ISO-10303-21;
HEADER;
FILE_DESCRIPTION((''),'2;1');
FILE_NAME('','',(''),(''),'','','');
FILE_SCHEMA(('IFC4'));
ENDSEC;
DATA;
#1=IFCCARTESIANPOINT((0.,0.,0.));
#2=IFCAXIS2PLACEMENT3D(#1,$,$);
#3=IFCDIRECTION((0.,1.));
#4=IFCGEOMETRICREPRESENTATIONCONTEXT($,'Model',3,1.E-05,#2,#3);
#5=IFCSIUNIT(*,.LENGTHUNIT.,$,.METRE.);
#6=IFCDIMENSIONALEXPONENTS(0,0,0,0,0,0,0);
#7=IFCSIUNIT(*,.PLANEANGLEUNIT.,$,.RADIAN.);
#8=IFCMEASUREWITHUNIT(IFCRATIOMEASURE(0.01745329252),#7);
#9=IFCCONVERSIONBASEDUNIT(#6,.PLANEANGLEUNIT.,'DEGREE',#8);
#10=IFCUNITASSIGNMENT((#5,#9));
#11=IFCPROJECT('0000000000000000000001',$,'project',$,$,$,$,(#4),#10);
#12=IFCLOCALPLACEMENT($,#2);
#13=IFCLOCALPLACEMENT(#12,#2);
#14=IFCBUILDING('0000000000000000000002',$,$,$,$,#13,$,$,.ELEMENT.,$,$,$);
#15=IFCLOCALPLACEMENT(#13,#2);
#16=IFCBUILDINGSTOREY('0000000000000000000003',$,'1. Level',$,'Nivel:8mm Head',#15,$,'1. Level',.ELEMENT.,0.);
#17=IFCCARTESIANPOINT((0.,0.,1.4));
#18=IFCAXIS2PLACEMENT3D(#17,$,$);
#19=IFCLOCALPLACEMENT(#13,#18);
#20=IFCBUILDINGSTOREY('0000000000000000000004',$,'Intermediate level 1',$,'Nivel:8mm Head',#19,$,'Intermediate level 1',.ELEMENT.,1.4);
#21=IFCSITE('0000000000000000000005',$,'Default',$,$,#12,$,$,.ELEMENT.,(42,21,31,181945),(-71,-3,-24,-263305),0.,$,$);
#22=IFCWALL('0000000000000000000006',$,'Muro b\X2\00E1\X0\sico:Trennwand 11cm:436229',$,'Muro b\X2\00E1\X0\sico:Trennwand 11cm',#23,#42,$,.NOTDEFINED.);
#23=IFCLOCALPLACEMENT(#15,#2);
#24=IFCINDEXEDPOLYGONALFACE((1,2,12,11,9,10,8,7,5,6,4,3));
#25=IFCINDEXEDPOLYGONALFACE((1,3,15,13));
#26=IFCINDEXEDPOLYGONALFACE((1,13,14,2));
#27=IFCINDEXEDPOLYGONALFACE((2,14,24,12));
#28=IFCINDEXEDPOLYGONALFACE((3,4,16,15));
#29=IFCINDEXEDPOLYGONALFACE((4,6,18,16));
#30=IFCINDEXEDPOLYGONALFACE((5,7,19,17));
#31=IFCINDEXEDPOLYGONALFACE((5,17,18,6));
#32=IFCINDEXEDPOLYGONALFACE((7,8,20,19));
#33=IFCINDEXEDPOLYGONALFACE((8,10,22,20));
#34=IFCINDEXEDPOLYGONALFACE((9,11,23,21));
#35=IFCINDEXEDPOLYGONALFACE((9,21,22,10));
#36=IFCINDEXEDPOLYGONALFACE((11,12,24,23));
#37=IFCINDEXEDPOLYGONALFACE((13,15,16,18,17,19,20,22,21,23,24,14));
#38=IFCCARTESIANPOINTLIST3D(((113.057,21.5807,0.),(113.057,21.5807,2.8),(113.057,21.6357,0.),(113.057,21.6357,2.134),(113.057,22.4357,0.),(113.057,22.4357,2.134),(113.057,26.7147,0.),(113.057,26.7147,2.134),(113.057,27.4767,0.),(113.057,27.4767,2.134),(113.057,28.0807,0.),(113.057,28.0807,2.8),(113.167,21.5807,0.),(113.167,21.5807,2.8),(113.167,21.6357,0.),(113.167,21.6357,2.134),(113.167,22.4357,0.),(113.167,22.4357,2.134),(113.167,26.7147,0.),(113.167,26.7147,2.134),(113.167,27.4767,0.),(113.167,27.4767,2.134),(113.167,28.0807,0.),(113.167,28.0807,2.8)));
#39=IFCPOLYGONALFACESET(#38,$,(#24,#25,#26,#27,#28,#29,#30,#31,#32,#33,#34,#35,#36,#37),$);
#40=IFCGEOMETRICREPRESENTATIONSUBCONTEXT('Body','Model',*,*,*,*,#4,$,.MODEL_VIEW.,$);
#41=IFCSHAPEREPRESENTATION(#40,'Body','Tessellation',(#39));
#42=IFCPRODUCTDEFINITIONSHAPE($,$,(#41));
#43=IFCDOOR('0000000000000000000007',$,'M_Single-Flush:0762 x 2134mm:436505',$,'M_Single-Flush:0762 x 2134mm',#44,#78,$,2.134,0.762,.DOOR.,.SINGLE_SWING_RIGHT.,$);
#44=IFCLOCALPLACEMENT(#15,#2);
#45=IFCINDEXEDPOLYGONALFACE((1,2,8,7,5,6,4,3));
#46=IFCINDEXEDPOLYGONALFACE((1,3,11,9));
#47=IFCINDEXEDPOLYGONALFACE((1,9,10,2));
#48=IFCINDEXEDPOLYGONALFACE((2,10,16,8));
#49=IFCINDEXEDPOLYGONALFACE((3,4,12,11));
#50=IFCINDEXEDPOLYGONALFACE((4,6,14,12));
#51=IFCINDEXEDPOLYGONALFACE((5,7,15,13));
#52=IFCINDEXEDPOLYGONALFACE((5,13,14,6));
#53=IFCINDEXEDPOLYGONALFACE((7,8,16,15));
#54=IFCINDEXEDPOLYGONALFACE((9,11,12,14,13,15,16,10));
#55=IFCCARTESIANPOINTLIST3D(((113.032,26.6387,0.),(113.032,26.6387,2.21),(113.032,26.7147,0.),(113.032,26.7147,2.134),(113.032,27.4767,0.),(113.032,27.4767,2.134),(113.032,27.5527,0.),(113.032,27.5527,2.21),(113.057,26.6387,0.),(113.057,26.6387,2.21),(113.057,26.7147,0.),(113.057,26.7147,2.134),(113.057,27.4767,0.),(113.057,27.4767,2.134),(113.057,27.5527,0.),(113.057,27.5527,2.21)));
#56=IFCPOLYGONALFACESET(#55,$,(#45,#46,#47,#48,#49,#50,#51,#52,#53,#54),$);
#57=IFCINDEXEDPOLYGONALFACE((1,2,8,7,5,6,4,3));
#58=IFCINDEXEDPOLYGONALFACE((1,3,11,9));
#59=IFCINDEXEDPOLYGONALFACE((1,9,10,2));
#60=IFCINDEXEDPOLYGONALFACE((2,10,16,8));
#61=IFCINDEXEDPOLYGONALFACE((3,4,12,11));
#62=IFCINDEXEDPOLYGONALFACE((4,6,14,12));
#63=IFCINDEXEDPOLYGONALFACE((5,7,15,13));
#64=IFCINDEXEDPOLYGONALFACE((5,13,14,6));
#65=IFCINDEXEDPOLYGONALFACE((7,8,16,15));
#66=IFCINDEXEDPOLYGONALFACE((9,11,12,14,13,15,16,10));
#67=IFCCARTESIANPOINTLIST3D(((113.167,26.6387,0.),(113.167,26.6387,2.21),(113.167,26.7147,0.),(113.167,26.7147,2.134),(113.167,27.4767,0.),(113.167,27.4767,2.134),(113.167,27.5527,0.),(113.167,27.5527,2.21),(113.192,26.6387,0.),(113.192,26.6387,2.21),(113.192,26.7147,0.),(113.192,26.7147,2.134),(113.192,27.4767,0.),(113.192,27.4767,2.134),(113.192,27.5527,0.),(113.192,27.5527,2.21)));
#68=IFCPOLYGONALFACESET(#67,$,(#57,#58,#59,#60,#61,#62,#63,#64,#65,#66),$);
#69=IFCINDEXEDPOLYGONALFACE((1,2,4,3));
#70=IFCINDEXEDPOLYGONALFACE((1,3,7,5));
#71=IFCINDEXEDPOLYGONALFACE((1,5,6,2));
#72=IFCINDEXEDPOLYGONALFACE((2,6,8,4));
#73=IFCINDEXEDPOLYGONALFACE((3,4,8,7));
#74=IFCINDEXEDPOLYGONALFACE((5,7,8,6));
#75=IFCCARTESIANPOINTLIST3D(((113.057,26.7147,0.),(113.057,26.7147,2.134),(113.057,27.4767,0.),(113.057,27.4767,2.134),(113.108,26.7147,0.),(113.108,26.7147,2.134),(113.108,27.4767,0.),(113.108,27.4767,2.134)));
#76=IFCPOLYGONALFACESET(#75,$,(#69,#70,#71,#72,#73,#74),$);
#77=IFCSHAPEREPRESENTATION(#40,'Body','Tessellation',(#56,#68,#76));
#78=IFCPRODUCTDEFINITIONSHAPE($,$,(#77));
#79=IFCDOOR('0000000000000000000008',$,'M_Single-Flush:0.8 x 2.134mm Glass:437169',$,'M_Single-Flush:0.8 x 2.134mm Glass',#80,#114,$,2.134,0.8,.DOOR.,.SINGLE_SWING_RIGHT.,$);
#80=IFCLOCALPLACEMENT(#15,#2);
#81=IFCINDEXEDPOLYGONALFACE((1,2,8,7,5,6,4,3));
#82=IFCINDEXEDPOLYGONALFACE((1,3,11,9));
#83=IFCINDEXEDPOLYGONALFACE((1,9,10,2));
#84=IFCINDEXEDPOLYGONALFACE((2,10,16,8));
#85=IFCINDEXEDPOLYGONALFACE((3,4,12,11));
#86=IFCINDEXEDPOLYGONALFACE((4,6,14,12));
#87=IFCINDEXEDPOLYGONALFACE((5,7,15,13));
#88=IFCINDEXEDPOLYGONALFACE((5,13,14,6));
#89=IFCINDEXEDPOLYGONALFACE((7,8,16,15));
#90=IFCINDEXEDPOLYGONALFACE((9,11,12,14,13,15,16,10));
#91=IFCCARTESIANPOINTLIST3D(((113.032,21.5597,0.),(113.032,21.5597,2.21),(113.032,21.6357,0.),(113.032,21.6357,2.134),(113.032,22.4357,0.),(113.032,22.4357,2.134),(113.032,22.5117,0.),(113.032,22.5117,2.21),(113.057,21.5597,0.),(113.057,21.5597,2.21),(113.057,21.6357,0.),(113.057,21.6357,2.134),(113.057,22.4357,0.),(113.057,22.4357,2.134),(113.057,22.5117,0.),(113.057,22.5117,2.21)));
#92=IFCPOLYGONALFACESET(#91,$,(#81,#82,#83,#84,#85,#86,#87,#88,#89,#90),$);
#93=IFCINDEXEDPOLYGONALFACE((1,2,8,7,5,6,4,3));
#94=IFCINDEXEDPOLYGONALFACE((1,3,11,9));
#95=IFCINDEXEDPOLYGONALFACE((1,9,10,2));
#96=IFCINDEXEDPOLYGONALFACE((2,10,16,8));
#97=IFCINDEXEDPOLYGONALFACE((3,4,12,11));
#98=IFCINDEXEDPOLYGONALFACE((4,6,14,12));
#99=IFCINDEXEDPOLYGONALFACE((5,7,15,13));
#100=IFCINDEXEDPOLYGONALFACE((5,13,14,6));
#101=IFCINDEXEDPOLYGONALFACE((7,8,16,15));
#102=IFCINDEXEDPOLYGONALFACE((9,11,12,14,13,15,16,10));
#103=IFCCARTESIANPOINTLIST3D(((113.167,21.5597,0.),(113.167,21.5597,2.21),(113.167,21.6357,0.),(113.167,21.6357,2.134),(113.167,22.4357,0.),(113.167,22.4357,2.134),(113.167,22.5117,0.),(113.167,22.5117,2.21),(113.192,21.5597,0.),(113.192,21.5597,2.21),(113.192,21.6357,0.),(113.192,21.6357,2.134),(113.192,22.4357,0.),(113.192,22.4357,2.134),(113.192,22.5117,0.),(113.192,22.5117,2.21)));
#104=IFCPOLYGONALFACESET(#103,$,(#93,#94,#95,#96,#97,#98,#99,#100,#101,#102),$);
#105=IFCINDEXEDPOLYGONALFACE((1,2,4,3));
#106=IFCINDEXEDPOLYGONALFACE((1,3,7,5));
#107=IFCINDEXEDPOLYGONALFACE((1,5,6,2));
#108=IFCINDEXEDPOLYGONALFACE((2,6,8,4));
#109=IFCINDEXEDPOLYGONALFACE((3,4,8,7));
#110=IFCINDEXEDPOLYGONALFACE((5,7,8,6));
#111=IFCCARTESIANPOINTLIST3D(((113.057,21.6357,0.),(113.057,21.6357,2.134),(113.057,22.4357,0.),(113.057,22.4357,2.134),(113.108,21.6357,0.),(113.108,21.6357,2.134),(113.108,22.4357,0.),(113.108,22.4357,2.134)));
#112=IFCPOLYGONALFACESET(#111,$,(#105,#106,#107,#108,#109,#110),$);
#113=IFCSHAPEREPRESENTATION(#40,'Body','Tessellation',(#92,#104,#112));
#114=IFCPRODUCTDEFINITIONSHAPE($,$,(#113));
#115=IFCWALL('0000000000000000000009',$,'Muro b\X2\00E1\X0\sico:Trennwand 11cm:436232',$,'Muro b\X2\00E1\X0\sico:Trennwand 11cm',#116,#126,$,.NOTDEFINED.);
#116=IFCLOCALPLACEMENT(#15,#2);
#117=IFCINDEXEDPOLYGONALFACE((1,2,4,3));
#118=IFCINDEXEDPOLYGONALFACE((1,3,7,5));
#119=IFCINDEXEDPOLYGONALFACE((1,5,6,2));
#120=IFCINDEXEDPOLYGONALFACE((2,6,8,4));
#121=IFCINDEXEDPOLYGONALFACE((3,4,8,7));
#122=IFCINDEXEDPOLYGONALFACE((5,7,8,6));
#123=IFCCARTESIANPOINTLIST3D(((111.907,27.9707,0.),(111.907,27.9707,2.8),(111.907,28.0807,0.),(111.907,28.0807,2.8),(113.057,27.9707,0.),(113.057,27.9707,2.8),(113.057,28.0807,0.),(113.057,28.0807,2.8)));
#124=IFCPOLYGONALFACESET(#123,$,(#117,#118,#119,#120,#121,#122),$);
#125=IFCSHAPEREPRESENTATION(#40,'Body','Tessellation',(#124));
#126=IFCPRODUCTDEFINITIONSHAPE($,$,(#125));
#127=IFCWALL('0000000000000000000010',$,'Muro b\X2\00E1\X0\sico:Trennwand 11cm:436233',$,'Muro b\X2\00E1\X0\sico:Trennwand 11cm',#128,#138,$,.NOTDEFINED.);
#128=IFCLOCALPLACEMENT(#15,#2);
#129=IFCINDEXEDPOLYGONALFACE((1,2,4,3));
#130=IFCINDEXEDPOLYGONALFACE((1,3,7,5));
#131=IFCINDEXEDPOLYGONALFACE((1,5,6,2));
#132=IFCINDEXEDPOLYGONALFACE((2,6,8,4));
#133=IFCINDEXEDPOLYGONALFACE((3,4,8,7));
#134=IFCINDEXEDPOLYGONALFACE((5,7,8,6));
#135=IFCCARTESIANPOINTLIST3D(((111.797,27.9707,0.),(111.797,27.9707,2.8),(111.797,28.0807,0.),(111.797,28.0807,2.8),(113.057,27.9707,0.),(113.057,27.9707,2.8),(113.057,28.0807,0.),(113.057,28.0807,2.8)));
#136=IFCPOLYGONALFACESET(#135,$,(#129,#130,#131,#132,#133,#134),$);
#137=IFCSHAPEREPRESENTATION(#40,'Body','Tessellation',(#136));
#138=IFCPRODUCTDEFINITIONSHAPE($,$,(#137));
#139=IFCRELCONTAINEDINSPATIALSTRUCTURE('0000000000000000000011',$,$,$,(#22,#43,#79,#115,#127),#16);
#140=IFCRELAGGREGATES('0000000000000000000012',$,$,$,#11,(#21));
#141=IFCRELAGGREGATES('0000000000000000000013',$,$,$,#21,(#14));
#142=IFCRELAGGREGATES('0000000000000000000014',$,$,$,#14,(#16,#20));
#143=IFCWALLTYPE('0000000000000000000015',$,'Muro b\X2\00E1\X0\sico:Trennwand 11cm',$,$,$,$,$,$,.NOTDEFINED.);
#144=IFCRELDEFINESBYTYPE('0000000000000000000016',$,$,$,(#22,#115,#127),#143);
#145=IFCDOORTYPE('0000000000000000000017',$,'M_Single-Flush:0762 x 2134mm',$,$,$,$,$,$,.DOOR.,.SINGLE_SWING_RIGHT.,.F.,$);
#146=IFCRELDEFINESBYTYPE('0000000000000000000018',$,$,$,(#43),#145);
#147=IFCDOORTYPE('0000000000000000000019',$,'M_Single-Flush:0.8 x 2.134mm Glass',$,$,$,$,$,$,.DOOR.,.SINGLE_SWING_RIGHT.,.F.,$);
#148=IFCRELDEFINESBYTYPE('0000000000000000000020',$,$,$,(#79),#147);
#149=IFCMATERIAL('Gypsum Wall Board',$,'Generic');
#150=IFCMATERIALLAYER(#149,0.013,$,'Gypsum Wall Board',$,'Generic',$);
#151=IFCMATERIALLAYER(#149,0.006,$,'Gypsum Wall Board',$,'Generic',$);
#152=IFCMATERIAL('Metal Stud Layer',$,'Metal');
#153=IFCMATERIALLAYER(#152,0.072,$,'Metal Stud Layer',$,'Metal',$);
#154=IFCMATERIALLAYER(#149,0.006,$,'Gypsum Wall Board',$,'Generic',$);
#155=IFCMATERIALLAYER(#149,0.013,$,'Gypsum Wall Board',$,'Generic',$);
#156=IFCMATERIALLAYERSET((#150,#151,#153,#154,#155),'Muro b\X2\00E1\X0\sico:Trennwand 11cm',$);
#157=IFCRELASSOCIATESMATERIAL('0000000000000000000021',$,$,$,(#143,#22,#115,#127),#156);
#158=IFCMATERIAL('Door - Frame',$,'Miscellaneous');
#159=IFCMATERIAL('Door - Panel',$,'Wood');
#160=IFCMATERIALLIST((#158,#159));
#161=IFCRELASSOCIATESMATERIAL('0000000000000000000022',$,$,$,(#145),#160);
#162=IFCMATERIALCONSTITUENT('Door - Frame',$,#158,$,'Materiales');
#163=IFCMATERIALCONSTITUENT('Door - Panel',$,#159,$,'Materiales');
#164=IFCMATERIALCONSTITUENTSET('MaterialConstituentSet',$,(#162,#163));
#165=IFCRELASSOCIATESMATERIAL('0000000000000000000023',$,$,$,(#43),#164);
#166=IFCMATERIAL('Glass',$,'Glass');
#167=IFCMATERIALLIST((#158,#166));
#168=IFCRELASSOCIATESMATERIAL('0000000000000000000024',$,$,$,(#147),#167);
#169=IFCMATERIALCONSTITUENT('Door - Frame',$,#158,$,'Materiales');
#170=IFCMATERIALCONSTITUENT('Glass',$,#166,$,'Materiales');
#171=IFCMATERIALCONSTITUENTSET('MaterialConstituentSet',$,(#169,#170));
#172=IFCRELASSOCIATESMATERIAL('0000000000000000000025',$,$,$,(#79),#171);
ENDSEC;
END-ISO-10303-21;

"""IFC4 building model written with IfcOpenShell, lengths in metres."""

from ifc_helpers import new_model, entity, si_unit, converted_unit, direction, frame, frame_2d, origin, origin_2d_with_axis, place, context, subcontext, project, spatial, polyline, rectangle, outline, extrude, source, transform, mapped, material, material_list, layer, layer_set, layer_usage, constituent, constituent_set, type_object, type_shapes, element, fill, save


model = new_model("IFC4")

# Units and contexts
model_context = context("Model", 3, precision=1e-05, world=origin(), true_north=direction((0.0, 1.0)))
body_context = subcontext(model_context, "Body", "Model", "MODEL_VIEW")
ifc_project = project(units=[si_unit("LENGTHUNIT", "METRE"), converted_unit("PLANEANGLEUNIT", "DEGREE", entity("IfcRatioMeasure", 0.01745329252), si_unit("PLANEANGLEUNIT", "RADIAN"), dimensions=[0, 0, 0, 0, 0, 0, 0])], contexts=[model_context])

# Site, building, storey
site_placement = place(None, origin())
site = spatial("IfcSite", under=ifc_project, at=site_placement, Name="Default", CompositionType="ELEMENT", RefLatitude=(42, 21, 31, 181945), RefLongitude=(-71, -3, -24, -263305), RefElevation=0.0)
building_placement = place(site_placement, origin())
building = spatial("IfcBuilding", under=site, at=building_placement, CompositionType="ELEMENT")
storey_1_placement = place(building_placement, origin())
storey_1 = spatial("IfcBuildingStorey", under=building, at=storey_1_placement, Name="1. Level", ObjectType="Nivel:8mm Head", LongName="1. Level", CompositionType="ELEMENT", Elevation=0.0)

# Shared definitions
storey_2_placement = place(building_placement, frame((0.0, 0.0, 1.4)))
storey_2 = spatial("IfcBuildingStorey", under=building, at=storey_2_placement, Name="Intermediate level 1", ObjectType="Nivel:8mm Head", LongName="Intermediate level 1", CompositionType="ELEMENT", Elevation=1.4)

# Shared definitions
ifc_material_1 = material(Name="Glass", Category="Glass")

# Wall, openings, doors
ifc_material_2 = material(Name="Gypsum Wall Board", Category="Generic")
ifc_layer_1 = layer(ifc_material_2, 0.013, Name="Gypsum Wall Board", Category="Generic")
ifc_layer_2 = layer(ifc_material_2, 0.006, Name="Gypsum Wall Board", Category="Generic")
ifc_material_3 = material(Name="Metal Stud Layer", Category="Metal")
ifc_layer_3 = layer(ifc_material_3, 0.072, Name="Metal Stud Layer", Category="Metal")
ifc_layer_4 = layer(ifc_material_2, 0.006, Name="Gypsum Wall Board", Category="Generic")
ifc_layer_5 = layer(ifc_material_2, 0.013, Name="Gypsum Wall Board", Category="Generic")
ifc_layer_set_1 = layer_set([ifc_layer_1, ifc_layer_2, ifc_layer_3, ifc_layer_4, ifc_layer_5], Name="Muro básico:Trennwand 11cm")
ifc_layer_usage_1 = layer_usage(ifc_layer_set_1, "AXIS2", "NEGATIVE", 0.055)
wall_type_1 = type_object("IfcWallType", Name="Muro básico:Trennwand 11cm", PredefinedType="NOTDEFINED", material=ifc_layer_set_1)
wall_1_placement = place(storey_1_placement, frame((113.112, 21.5807, 0.0), z_axis=(0.0, 0.0, 1.0), x_axis=(0.0, 1.0, 0.0)))
wall_1 = element("IfcWall", 1, at=wall_1_placement, inside=storey_1, type_object=wall_type_1, material=ifc_layer_usage_1, Name="Muro básico:Trennwand 11cm:436229", ObjectType="Muro básico:Trennwand 11cm", PredefinedType="NOTDEFINED", context=body_context, shape_type="SweptSolid", body=[
    extrude(rectangle(XDim=6.5, YDim=0.11, at=frame_2d((3.25, 0.0), x_axis=(-1.0, 0.0))), origin(), (0.0, 0.0, 1.0), 2.8),
])
opening_1_placement = place(wall_1_placement, frame((5.134, -0.055, 0.0)))
opening_1 = element("IfcOpeningElement", 2, at=opening_1_placement, cuts=wall_1, ObjectType="Opening", PredefinedType="OPENING", context=body_context, shape_type="SweptSolid", body=[
    extrude(rectangle(XDim=0.762, YDim=2.134, at=frame_2d((1.067, 0.381), x_axis=(0.0, 1.0))), frame((0.0, 0.0, 0.0), z_axis=(0.0, 1.0, 0.0), x_axis=(0.0, 0.0, 1.0)), (0.0, 0.0, 1.0), 0.11),
])
opening_2_placement = place(wall_1_placement, frame((0.055, -0.055, 0.0)))
opening_2 = element("IfcOpeningElement", 3, at=opening_2_placement, cuts=wall_1, ObjectType="Opening", PredefinedType="OPENING", context=body_context, shape_type="SweptSolid", body=[
    extrude(rectangle(XDim=0.8, YDim=2.134, at=frame_2d((1.067, 0.4), x_axis=(0.0, 1.0))), frame((0.0, 0.0, 0.0), z_axis=(0.0, 1.0, 0.0), x_axis=(0.0, 0.0, 1.0)), (0.0, 0.0, 1.0), 0.11),
])
ifc_material_4 = material(Name="Door - Frame", Category="Miscellaneous")
ifc_constituent_1 = constituent(ifc_material_4, Name="Door - Frame", Category="Materiales")
ifc_material_5 = material(Name="Door - Panel", Category="Wood")
ifc_constituent_2 = constituent(ifc_material_5, Name="Door - Panel", Category="Materiales")
ifc_constituent_set_1 = constituent_set(constituents=[ifc_constituent_1, ifc_constituent_2], Name="MaterialConstituentSet")
ifc_material_list_1 = material_list([ifc_material_4, ifc_material_5])
door_type_1 = type_object("IfcDoorType", Name="M_Single-Flush:0762 x 2134mm", OperationType="SINGLE_SWING_RIGHT", ParameterTakesPrecedence=False, PredefinedType="DOOR", material=ifc_material_list_1)
shared_shape_1 = source(origin(), body_context, "Body", "SweptSolid", [
    extrude(outline(polyline([(-0.457, -1.124), (0.457, -1.124), (0.457, 1.086), (0.381, 1.086), (0.381, -1.048), (-0.381, -1.048), (-0.381, 1.086), (-0.457, 1.086), (-0.457, -1.124)])), frame((0.381, 0.11, 1.086), z_axis=(0.0, 1.0, 0.0), x_axis=(1.0, 0.0, 0.0)), (0.0, 0.0, 1.0), 0.025),
    extrude(outline(polyline([(-1.124, -0.457), (1.086, -0.457), (1.086, -0.381), (-1.048, -0.381), (-1.048, 0.381), (1.086, 0.381), (1.086, 0.457), (-1.124, 0.457), (-1.124, -0.457)])), frame((0.381, -0.025, 1.086), z_axis=(0.0, 1.0, 0.0), x_axis=(0.0, 0.0, -1.0)), (0.0, 0.0, 1.0), 0.025),
    extrude(rectangle(XDim=0.051, YDim=0.762, at=origin_2d_with_axis()), frame((0.381, 0.0845, 0.0), z_axis=(0.0, 0.0, 1.0), x_axis=(0.0, 1.0, 0.0)), (0.0, 0.0, 1.0), 2.134),
])
type_shapes(door_type_1, [shared_shape_1])
door_1_placement = place(opening_1_placement, origin())
door_1 = element("IfcDoor", 4, at=door_1_placement, inside=storey_1, type_object=door_type_1, material=ifc_constituent_set_1, Name="M_Single-Flush:0762 x 2134mm:436505", ObjectType="M_Single-Flush:0762 x 2134mm", OperationType="SINGLE_SWING_RIGHT", OverallHeight=2.134, OverallWidth=0.762, PredefinedType="DOOR", context=body_context, shape_type="MappedRepresentation", body=[
    mapped(shared_shape_1, transform((0.0, 0.0, 0.0), scale=1.0)),
])
fill(opening_1, door_1)
ifc_constituent_3 = constituent(ifc_material_4, Name="Door - Frame", Category="Materiales")
ifc_constituent_4 = constituent(ifc_material_1, Name="Glass", Category="Materiales")
ifc_constituent_set_2 = constituent_set(constituents=[ifc_constituent_3, ifc_constituent_4], Name="MaterialConstituentSet")
ifc_material_list_2 = material_list([ifc_material_4, ifc_material_1])
door_type_2 = type_object("IfcDoorType", Name="M_Single-Flush:0.8 x 2.134mm Glass", OperationType="SINGLE_SWING_RIGHT", ParameterTakesPrecedence=False, PredefinedType="DOOR", material=ifc_material_list_2)
shared_shape_2 = source(origin(), body_context, "Body", "SweptSolid", [
    extrude(outline(polyline([(-0.476, -1.124), (0.476, -1.124), (0.476, 1.086), (0.4, 1.086), (0.4, -1.048), (-0.4, -1.048), (-0.4, 1.086), (-0.476, 1.086), (-0.476, -1.124)])), frame((0.4, 0.11, 1.086), z_axis=(0.0, 1.0, 0.0), x_axis=(1.0, 0.0, 0.0)), (0.0, 0.0, 1.0), 0.025),
    extrude(outline(polyline([(-1.124, -0.476), (1.086, -0.476), (1.086, -0.4), (-1.048, -0.4), (-1.048, 0.4), (1.086, 0.4), (1.086, 0.476), (-1.124, 0.476), (-1.124, -0.476)])), frame((0.4, -0.025, 1.086), z_axis=(0.0, 1.0, 0.0), x_axis=(0.0, 0.0, -1.0)), (0.0, 0.0, 1.0), 0.025),
    extrude(rectangle(XDim=0.051, YDim=0.8, at=origin_2d_with_axis()), frame((0.4, 0.0845, 0.0), z_axis=(0.0, 0.0, 1.0), x_axis=(0.0, 1.0, 0.0)), (0.0, 0.0, 1.0), 2.134),
])
type_shapes(door_type_2, [shared_shape_2])
door_2_placement = place(opening_2_placement, origin())
door_2 = element("IfcDoor", 5, at=door_2_placement, inside=storey_1, type_object=door_type_2, material=ifc_constituent_set_2, Name="M_Single-Flush:0.8 x 2.134mm Glass:437169", ObjectType="M_Single-Flush:0.8 x 2.134mm Glass", OperationType="SINGLE_SWING_RIGHT", OverallHeight=2.134, OverallWidth=0.8, PredefinedType="DOOR", context=body_context, shape_type="MappedRepresentation", body=[
    mapped(shared_shape_2, transform((0.0, 0.0, 0.0), scale=1.0)),
])
fill(opening_2, door_2)

# Walls
ifc_layer_usage_2 = layer_usage(ifc_layer_set_1, "AXIS2", "NEGATIVE", 0.055)
wall_2_placement = place(storey_1_placement, frame((113.057, 28.0257, 0.0), z_axis=(0.0, 0.0, 1.0), x_axis=(-1.0, 0.0, 0.0)))
element("IfcWall", 6, at=wall_2_placement, inside=storey_1, type_object=wall_type_1, material=ifc_layer_usage_2, Name="Muro básico:Trennwand 11cm:436232", ObjectType="Muro básico:Trennwand 11cm", PredefinedType="NOTDEFINED", context=body_context, shape_type="SweptSolid", body=[
    extrude(rectangle(XDim=1.15, YDim=0.11, at=frame_2d((0.575, 0.0), x_axis=(-1.0, 0.0))), origin(), (0.0, 0.0, 1.0), 2.8),
])
ifc_layer_usage_3 = layer_usage(ifc_layer_set_1, "AXIS2", "NEGATIVE", 0.055)
wall_3_placement = place(storey_1_placement, frame((113.057, 28.0257, 0.0), z_axis=(0.0, 0.0, 1.0), x_axis=(-1.0, 0.0, 0.0)))
element("IfcWall", 7, at=wall_3_placement, inside=storey_1, type_object=wall_type_1, material=ifc_layer_usage_3, Name="Muro básico:Trennwand 11cm:436233", ObjectType="Muro básico:Trennwand 11cm", PredefinedType="NOTDEFINED", context=body_context, shape_type="SweptSolid", body=[
    extrude(rectangle(XDim=1.26, YDim=0.11, at=frame_2d((0.63, 0.0), x_axis=(-1.0, 0.0))), origin(), (0.0, 0.0, 1.0), 2.8),
])

save(model, "model.ifc")
